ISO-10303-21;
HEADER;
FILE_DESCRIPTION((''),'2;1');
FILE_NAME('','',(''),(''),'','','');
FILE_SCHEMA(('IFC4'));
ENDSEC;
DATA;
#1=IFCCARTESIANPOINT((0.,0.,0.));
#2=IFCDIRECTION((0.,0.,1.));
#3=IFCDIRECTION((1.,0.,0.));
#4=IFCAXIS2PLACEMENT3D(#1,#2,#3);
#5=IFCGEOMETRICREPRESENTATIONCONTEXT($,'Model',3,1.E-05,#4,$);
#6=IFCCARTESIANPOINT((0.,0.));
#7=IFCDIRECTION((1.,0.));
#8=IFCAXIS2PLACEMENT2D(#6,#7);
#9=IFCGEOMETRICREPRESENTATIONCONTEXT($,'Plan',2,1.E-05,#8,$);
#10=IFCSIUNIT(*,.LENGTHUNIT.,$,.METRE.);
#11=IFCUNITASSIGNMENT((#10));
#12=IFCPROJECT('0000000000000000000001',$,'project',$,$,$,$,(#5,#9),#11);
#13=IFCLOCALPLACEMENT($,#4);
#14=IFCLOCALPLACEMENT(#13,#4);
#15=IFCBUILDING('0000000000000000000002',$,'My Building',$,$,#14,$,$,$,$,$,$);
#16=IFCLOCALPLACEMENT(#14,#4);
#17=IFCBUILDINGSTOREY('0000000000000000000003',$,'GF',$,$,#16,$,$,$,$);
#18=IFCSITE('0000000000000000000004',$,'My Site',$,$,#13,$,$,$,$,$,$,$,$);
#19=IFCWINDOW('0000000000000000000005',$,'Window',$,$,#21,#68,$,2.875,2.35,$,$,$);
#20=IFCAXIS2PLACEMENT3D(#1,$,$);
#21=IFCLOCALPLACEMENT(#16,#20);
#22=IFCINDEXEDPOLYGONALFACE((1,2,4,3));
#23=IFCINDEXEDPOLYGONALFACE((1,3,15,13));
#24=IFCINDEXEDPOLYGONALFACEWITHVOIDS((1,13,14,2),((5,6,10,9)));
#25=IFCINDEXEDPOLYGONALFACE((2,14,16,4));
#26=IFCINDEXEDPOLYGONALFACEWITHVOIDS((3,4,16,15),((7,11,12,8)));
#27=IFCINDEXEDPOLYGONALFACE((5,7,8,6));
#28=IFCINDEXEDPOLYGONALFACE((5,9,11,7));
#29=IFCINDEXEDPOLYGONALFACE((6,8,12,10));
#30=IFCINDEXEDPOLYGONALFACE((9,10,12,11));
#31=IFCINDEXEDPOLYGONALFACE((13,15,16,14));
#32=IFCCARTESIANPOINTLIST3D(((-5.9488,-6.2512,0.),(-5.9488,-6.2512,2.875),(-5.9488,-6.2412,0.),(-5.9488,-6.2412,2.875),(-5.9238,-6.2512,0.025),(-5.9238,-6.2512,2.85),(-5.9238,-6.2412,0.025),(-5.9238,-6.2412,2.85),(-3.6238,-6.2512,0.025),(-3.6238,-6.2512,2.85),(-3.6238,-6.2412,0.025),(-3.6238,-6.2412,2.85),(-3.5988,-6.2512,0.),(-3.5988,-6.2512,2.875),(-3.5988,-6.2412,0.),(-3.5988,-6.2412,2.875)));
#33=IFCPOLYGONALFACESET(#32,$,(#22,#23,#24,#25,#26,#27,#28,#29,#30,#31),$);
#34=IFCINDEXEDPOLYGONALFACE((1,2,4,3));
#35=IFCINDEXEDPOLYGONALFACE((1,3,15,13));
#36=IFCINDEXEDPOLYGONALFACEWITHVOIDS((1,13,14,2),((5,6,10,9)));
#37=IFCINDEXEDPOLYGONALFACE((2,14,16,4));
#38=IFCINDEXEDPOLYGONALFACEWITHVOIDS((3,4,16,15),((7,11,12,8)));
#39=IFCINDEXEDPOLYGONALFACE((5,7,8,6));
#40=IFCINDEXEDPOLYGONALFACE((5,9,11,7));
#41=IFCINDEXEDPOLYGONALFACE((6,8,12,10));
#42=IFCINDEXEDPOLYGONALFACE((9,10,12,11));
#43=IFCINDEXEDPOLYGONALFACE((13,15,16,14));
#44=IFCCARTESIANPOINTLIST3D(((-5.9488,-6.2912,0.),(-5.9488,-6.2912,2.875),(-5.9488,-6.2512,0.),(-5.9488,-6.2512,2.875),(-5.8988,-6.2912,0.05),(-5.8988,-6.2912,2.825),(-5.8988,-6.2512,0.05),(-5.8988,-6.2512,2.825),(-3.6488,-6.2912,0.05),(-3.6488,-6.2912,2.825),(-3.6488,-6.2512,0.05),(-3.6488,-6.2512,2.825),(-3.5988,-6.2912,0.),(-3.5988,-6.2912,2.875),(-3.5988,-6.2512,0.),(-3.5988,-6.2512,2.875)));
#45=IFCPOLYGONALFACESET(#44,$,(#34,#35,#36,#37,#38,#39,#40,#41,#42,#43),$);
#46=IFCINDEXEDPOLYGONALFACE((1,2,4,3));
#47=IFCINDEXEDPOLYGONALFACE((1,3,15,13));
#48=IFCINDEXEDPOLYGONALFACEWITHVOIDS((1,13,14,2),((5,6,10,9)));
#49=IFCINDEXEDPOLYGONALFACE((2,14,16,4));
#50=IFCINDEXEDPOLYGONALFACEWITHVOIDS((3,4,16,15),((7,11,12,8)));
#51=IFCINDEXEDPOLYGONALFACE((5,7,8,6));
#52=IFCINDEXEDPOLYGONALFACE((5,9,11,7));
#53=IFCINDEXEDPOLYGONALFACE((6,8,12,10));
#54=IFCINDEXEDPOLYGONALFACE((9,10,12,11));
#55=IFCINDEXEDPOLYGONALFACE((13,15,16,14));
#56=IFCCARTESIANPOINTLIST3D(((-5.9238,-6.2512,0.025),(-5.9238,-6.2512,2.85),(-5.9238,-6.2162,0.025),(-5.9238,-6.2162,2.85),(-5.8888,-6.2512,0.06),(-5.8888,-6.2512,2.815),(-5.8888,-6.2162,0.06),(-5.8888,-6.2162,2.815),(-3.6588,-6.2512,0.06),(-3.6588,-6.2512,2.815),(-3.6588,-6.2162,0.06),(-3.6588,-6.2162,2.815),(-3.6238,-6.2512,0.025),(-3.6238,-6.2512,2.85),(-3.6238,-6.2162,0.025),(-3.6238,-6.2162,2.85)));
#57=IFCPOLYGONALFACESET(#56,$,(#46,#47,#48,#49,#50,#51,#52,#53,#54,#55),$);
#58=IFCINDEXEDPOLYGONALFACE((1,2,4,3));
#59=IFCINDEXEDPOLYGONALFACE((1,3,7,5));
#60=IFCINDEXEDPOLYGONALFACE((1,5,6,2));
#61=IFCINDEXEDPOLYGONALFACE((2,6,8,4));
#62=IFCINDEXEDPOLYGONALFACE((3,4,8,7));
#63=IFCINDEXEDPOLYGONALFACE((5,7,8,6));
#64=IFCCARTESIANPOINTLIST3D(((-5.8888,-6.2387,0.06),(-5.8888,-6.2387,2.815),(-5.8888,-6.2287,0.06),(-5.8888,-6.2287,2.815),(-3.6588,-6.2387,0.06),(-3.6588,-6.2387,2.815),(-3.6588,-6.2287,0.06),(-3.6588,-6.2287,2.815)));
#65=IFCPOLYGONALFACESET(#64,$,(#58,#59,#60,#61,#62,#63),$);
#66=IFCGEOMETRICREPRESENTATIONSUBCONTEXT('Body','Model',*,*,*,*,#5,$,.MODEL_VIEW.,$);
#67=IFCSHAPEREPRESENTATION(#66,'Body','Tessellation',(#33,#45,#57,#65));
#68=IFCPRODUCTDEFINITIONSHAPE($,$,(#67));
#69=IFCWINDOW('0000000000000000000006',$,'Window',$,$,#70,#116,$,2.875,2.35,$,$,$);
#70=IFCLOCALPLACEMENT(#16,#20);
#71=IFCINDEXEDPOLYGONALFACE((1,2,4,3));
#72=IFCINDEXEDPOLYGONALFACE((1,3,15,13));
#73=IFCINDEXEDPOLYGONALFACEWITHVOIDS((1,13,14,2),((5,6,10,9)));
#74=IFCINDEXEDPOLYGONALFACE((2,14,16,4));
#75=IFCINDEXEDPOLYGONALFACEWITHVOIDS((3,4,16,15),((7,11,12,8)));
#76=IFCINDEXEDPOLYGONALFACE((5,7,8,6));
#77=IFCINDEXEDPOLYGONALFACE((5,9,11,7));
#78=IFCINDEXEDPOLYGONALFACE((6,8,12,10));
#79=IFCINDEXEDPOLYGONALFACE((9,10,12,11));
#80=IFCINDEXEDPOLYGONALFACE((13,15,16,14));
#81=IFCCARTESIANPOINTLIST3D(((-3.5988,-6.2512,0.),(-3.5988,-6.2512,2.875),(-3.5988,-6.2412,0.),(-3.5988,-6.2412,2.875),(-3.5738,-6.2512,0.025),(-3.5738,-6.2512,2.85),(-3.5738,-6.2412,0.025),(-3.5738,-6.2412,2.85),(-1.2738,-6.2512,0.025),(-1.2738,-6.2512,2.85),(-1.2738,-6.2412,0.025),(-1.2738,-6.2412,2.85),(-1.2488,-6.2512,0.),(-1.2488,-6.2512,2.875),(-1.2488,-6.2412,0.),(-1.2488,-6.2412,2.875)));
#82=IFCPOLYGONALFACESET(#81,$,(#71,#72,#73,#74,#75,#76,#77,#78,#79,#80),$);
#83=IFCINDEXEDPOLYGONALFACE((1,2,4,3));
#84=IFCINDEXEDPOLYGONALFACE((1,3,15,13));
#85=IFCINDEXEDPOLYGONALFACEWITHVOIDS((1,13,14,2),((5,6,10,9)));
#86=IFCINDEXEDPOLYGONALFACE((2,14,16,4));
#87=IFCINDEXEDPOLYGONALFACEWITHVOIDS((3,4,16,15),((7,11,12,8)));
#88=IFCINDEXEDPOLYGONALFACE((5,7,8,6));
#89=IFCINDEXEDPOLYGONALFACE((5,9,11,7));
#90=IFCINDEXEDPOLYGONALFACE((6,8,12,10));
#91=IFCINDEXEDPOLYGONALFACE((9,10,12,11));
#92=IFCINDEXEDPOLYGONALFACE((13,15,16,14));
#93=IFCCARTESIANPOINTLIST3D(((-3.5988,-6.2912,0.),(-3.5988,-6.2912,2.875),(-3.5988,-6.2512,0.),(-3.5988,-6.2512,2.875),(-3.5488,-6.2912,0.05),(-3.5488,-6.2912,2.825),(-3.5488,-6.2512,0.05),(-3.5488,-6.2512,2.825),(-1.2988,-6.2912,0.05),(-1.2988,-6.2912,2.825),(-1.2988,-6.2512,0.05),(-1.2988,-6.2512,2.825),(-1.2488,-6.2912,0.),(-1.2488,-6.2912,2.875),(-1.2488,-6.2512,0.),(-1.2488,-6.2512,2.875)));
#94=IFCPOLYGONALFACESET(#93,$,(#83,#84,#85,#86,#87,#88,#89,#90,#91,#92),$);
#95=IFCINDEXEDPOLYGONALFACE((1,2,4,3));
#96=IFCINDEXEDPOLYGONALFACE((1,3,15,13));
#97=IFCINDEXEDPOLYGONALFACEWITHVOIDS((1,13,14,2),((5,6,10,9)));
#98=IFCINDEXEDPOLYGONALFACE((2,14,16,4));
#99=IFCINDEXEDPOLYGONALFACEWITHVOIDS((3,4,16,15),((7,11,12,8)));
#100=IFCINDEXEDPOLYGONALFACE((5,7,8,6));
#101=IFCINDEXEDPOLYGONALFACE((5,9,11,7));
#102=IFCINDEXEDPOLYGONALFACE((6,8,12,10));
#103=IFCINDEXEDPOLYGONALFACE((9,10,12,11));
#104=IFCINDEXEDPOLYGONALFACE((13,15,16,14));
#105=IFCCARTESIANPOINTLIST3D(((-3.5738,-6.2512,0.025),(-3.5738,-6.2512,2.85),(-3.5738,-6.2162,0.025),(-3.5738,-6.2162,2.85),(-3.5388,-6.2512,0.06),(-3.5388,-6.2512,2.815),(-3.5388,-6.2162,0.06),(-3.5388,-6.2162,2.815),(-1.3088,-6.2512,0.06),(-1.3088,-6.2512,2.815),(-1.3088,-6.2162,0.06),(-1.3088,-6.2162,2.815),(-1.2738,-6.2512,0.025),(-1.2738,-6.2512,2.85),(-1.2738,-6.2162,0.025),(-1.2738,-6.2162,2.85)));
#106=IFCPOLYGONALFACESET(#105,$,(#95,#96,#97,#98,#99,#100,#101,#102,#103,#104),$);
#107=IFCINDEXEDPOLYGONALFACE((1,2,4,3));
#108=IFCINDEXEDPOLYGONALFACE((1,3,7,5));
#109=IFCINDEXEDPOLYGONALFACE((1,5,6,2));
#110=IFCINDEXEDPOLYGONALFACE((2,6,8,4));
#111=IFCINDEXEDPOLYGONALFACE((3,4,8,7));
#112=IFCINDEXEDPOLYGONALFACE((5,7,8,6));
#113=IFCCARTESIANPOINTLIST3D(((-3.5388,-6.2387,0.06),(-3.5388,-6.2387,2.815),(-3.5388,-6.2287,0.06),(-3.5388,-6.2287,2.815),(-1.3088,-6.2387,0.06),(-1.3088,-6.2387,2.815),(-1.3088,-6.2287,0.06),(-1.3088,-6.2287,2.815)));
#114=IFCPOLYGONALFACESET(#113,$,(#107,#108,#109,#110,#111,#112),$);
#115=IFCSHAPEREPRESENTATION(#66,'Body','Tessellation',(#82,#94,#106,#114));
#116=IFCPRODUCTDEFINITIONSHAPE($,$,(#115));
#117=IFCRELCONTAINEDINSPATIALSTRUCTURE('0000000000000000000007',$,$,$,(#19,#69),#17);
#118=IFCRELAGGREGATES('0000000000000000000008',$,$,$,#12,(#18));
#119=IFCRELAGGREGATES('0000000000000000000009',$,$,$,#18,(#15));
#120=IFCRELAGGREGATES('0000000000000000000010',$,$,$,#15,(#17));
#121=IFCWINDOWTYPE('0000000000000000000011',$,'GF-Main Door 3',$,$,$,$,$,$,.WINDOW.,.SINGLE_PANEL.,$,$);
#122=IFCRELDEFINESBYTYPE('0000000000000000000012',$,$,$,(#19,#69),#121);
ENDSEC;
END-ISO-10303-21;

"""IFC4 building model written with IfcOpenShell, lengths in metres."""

from ifc_helpers import new_model, entity, si_unit, frame, origin_with_axes, origin_2d_with_axis, place, context, subcontext, project, spatial, line, indexed_curve, outline, extrude, shape, source, transform, mapped, type_object, type_shapes, element, save


model = new_model("IFC4")

# Units and contexts
model_context = context("Model", 3, precision=1e-05, world=origin_with_axes())
plan_context = context("Plan", 2, precision=1e-05, world=origin_2d_with_axis())
body_context_1 = subcontext(model_context, "Body", "Model", "MODEL_VIEW")
body_context_2 = subcontext(plan_context, "Body", "Plan", "PLAN_VIEW")
ifc_project = project(units=[si_unit("LENGTHUNIT", "METRE")], contexts=[model_context, plan_context])

# Site, building, storey
site_placement = place(None, origin_with_axes())
site = spatial("IfcSite", under=ifc_project, at=site_placement, Name="My Site")
building_placement = place(site_placement, origin_with_axes())
building = spatial("IfcBuilding", under=site, at=building_placement, Name="My Building")
storey_placement = place(building_placement, origin_with_axes())
storey = spatial("IfcBuildingStorey", under=building, at=storey_placement, Name="GF")

# Windows
window_type_1 = type_object("IfcWindowType", Name="GF-Main Door 3", PartitioningType="SINGLE_PANEL", PredefinedType="WINDOW")
shared_shape_1 = source(origin_with_axes(), body_context_1, "Body", "SweptSolid", [
    extrude(outline(indexed_curve([(0.0, 0.0), (2.35, 0.0), (2.35, 2.875), (0.0, 2.875)], segments=[line(1, 2, 3, 4, 1)]), holes=[indexed_curve([(0.025, 0.025), (2.325, 0.025), (2.325, 2.85), (0.025, 2.85)], segments=[line(1, 2, 3, 4, 1)])]), frame((0.0, 0.09, 0.0), z_axis=(0.0, -1.0, 0.0), x_axis=(1.0, 0.0, 0.0)), (0.0, 0.0, -1.0), 0.01),
    extrude(outline(indexed_curve([(0.0, 0.0), (2.35, 0.0), (2.35, 2.875), (0.0, 2.875)], segments=[line(1, 2, 3, 4, 1)]), holes=[indexed_curve([(0.05, 0.05), (2.3, 0.05), (2.3, 2.825), (0.05, 2.825)], segments=[line(1, 2, 3, 4, 1)])]), frame((0.0, 0.05, 0.0), z_axis=(0.0, -1.0, 0.0), x_axis=(1.0, 0.0, 0.0)), (0.0, 0.0, -1.0), 0.04),
    extrude(outline(indexed_curve([(0.0, 0.0), (2.3, 0.0), (2.3, 2.825), (0.0, 2.825)], segments=[line(1, 2, 3, 4, 1)]), holes=[indexed_curve([(0.035, 0.035), (2.265, 0.035), (2.265, 2.79), (0.035, 2.79)], segments=[line(1, 2, 3, 4, 1)])]), frame((0.025, 0.09, 0.025), z_axis=(0.0, -1.0, 0.0), x_axis=(1.0, 0.0, 0.0)), (0.0, 0.0, -1.0), 0.035),
    extrude(outline(indexed_curve([(0.035, 0.035), (2.265, 0.035), (2.265, 2.79), (0.035, 2.79)], segments=[line(1, 2, 3, 4, 1)])), frame((0.025, 0.1025, 0.025), z_axis=(0.0, -1.0, 0.0), x_axis=(1.0, 0.0, 0.0)), (0.0, 0.0, -1.0), 0.01),
])
shared_shape_2 = source(origin_with_axes(), body_context_2, "Body", "Curve2D", [
    entity("IfcIndexedPolyCurve", entity("IfcCartesianPointList2D", [[0.05, 0.05], [2.3, 0.05]])),
    entity("IfcIndexedPolyCurve", entity("IfcCartesianPointList2D", [[0.0, 0.1], [0.025, 0.1], [0.025, 0.09], [0.05, 0.09], [0.05, 0.05], [0.0, 0.05]]), [entity("IfcLineIndex", [1, 2, 3, 4, 5, 6, 1])]),
    entity("IfcIndexedPolyCurve", entity("IfcCartesianPointList2D", [[2.35, 0.1], [2.325, 0.1], [2.325, 0.09], [2.3, 0.09], [2.3, 0.05], [2.35, 0.05]]), [entity("IfcLineIndex", [1, 2, 3, 4, 5, 6, 1])]),
    entity("IfcIndexedPolyCurve", entity("IfcCartesianPointList2D", [[0.025, 0.09], [0.06, 0.09], [0.06, 0.125], [0.025, 0.125]]), [entity("IfcLineIndex", [1, 2, 3, 4, 1])]),
    entity("IfcIndexedPolyCurve", entity("IfcCartesianPointList2D", [[2.325, 0.09], [2.29, 0.09], [2.29, 0.125], [2.325, 0.125]]), [entity("IfcLineIndex", [1, 2, 3, 4, 1])]),
    entity("IfcIndexedPolyCurve", entity("IfcCartesianPointList2D", [[0.06, 0.09], [2.29, 0.09]])),
    entity("IfcIndexedPolyCurve", entity("IfcCartesianPointList2D", [[0.06, 0.125], [2.29, 0.125]])),
    entity("IfcIndexedPolyCurve", entity("IfcCartesianPointList2D", [[0.06, 0.1075], [2.29, 0.1075]])),
])
type_shapes(window_type_1, [shared_shape_1, shared_shape_2])
for number, where, z_axis, x_axis, name in (
    (1, (-5.9488, -6.3412, 0.0), (0.0, 0.0, 1.0), (1.0, 0.0, 0.0), "Window"),
    (2, (-3.5988, -6.3412, 0.0), (0.0, 0.0, 1.0), (1.0, 0.0, 0.0), "Window"),
):
    element("IfcWindow", number, at=place(storey_placement, frame(where, z_axis=z_axis, x_axis=x_axis)), inside=storey, type_object=window_type_1, Name=name, OverallHeight=2.875, OverallWidth=2.35, shapes=[
        shape(body_context_1, "Body", "MappedRepresentation", [mapped(shared_shape_1, transform((0.0, 0.0, 0.0), x_axis=(1.0, 0.0, 0.0), y_axis=(0.0, 1.0, 0.0), z_axis=(0.0, 0.0, 1.0), scale=1.0))]),
        shape(body_context_2, "Body", "MappedRepresentation", [mapped(shared_shape_2, transform((0.0, 0.0, 0.0), x_axis=(1.0, 0.0, 0.0), y_axis=(0.0, 1.0, 0.0), z_axis=(0.0, 0.0, 1.0), scale=1.0))]),
    ])

save(model, "model.ifc")
